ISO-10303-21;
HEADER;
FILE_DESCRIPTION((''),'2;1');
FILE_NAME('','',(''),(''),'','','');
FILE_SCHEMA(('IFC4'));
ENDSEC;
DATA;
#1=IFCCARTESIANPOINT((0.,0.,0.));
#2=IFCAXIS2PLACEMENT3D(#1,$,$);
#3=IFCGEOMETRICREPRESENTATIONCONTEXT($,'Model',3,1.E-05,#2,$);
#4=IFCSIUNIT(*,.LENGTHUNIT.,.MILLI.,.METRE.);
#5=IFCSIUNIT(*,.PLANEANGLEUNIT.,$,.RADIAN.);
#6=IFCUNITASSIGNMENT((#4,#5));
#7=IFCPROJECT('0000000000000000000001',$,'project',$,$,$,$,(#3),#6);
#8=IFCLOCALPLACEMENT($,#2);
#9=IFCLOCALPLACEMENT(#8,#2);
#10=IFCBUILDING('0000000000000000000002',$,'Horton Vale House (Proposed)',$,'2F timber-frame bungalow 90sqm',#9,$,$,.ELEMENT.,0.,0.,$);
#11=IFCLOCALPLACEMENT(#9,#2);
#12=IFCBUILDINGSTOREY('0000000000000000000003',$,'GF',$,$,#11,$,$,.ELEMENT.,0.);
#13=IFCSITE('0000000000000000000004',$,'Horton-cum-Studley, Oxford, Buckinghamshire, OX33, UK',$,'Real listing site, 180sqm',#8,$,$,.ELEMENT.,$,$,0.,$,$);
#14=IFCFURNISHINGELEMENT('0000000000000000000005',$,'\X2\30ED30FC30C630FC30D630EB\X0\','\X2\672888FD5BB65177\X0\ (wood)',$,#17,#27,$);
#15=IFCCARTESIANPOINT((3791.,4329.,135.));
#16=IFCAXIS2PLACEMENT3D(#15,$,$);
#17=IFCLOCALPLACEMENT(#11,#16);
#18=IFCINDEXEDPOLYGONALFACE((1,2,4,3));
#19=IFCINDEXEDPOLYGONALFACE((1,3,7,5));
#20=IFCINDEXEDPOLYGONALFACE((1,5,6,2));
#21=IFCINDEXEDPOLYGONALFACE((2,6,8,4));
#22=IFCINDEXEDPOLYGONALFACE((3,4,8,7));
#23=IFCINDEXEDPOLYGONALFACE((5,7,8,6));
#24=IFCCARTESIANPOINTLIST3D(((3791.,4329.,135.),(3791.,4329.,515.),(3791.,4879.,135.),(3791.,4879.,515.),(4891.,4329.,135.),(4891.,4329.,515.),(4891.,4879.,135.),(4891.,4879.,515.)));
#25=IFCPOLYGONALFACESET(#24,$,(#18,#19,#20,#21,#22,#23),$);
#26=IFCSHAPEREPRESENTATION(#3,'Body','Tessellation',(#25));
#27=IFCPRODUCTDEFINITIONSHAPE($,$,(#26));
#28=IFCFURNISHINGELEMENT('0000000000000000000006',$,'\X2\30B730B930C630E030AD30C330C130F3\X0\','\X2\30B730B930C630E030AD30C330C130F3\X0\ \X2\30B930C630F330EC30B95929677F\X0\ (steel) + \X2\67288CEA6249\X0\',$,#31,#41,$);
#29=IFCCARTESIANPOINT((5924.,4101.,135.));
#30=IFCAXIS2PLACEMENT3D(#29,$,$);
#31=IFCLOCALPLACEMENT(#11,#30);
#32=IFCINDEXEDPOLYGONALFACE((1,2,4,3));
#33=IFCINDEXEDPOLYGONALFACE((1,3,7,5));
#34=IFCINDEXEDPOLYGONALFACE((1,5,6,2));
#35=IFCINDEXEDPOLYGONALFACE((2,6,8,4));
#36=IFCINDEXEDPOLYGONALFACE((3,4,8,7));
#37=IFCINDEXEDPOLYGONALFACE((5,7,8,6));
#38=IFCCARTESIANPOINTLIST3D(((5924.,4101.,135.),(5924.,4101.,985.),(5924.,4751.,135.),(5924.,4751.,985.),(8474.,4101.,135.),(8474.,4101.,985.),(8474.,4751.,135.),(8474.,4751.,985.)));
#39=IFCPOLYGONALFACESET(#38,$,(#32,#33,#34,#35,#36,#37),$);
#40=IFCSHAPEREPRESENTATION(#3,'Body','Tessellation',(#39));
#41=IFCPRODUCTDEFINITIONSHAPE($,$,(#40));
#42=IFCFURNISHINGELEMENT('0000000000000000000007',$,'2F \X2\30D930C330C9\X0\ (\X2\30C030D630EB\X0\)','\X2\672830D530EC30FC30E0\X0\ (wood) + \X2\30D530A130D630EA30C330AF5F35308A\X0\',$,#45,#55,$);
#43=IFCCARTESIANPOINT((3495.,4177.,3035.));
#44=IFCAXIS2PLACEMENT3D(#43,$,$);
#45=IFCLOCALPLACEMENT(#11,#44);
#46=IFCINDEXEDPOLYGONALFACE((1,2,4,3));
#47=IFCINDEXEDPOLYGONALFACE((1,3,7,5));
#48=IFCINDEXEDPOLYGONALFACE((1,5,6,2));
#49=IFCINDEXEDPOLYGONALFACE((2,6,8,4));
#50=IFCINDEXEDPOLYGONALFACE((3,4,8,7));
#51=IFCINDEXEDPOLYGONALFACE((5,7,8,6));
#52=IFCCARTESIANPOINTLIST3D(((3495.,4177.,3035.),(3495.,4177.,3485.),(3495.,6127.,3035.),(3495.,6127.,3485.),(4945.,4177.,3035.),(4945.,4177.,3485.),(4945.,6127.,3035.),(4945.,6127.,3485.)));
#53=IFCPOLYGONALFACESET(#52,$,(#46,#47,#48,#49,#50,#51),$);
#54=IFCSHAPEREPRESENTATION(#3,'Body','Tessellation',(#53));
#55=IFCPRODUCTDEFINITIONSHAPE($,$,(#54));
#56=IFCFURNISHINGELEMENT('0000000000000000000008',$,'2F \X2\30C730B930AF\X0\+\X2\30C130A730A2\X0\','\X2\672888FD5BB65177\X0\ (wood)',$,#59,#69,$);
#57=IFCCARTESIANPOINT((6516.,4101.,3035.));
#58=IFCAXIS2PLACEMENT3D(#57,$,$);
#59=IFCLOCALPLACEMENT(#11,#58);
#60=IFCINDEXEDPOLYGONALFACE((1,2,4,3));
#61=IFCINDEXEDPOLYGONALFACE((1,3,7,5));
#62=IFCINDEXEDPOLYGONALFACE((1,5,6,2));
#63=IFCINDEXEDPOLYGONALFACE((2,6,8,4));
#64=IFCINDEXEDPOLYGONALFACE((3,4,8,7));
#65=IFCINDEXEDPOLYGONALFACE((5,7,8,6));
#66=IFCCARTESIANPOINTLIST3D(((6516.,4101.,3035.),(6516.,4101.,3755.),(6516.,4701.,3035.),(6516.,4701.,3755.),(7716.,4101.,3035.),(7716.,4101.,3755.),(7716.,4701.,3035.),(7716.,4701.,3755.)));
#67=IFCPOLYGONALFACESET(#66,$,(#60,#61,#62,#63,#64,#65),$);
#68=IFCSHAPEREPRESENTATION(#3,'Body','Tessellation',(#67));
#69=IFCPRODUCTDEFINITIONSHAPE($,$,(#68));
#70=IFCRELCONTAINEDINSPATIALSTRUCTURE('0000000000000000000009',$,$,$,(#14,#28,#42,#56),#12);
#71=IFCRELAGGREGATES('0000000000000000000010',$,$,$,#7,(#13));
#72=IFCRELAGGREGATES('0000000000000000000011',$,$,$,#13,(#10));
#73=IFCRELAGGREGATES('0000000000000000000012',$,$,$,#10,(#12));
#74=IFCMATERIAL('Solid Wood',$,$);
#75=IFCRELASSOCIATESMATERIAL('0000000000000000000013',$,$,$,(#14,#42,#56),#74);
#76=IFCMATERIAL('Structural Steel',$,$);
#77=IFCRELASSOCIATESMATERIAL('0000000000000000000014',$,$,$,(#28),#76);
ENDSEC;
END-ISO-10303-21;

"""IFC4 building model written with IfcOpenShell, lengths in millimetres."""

from ifc_helpers import new_model, si_unit, frame, frame_2d, origin, place, context, project, spatial, rectangle, extrude, material, element, save


model = new_model("IFC4")

# Units and contexts
model_context = context("Model", 3, precision=1e-05, world=origin())
ifc_project = project(units=[si_unit("LENGTHUNIT", "METRE", prefix="MILLI"), si_unit("PLANEANGLEUNIT", "RADIAN")], contexts=[model_context])

# Site, building, storey
site_placement = place(None, origin())
site = spatial("IfcSite", under=ifc_project, at=site_placement, Name="Horton-cum-Studley, Oxford, Buckinghamshire, OX33, UK", ObjectType="Real listing site, 180sqm", CompositionType="ELEMENT", RefElevation=0.0)
building_placement = place(site_placement, origin())
building = spatial("IfcBuilding", under=site, at=building_placement, Name="Horton Vale House (Proposed)", ObjectType="2F timber-frame bungalow 90sqm", CompositionType="ELEMENT", ElevationOfRefHeight=0.0, ElevationOfTerrain=0.0)
storey_placement = place(building_placement, origin())
storey = spatial("IfcBuildingStorey", under=building, at=storey_placement, Name="GF", CompositionType="ELEMENT", Elevation=0.0)

# Shared definitions
ifc_material_1 = material(Name="Solid Wood")

# Shared definitions
ifc_material_2 = material(Name="Structural Steel")

# Furnishing elements
furnishing_1_placement = place(storey_placement, frame((3791.0, 4329.0, 135.0)))
element("IfcFurnishingElement", 1, at=furnishing_1_placement, inside=storey, material=ifc_material_1, Name="ローテーブル", Description="木製家具 (wood)", context=model_context, shape_type="SweptSolid", body=[
    extrude(rectangle(XDim=1100.0, YDim=550.0, at=frame_2d((550.0, 275.0))), frame((3791.0, 4329.0, 135.0)), (0.0, 0.0, 1.0), 380.0),
])
furnishing_2_placement = place(storey_placement, frame((5924.0, 4101.0, 135.0)))
element("IfcFurnishingElement", 2, at=furnishing_2_placement, inside=storey, material=ifc_material_2, Name="システムキッチン", Description="システムキッチン ステンレス天板 (steel) + 木質扉", context=model_context, shape_type="SweptSolid", body=[
    extrude(rectangle(XDim=2550.0, YDim=650.0, at=frame_2d((1275.0, 325.0))), frame((5924.0, 4101.0, 135.0)), (0.0, 0.0, 1.0), 850.0),
])
furnishing_3_placement = place(storey_placement, frame((3495.0, 4177.0, 3035.0)))
element("IfcFurnishingElement", 3, at=furnishing_3_placement, inside=storey, material=ifc_material_1, Name="2F ベッド (ダブル)", Description="木フレーム (wood) + ファブリック張り", context=model_context, shape_type="SweptSolid", body=[
    extrude(rectangle(XDim=1450.0, YDim=1950.0, at=frame_2d((725.0, 975.0))), frame((3495.0, 4177.0, 3035.0)), (0.0, 0.0, 1.0), 450.0),
])
furnishing_4_placement = place(storey_placement, frame((6516.0, 4101.0, 3035.0)))
element("IfcFurnishingElement", 4, at=furnishing_4_placement, inside=storey, material=ifc_material_1, Name="2F デスク+チェア", Description="木製家具 (wood)", context=model_context, shape_type="SweptSolid", body=[
    extrude(rectangle(XDim=1200.0, YDim=600.0, at=frame_2d((600.0, 300.0))), frame((6516.0, 4101.0, 3035.0)), (0.0, 0.0, 1.0), 720.0),
])

save(model, "model.ifc")
